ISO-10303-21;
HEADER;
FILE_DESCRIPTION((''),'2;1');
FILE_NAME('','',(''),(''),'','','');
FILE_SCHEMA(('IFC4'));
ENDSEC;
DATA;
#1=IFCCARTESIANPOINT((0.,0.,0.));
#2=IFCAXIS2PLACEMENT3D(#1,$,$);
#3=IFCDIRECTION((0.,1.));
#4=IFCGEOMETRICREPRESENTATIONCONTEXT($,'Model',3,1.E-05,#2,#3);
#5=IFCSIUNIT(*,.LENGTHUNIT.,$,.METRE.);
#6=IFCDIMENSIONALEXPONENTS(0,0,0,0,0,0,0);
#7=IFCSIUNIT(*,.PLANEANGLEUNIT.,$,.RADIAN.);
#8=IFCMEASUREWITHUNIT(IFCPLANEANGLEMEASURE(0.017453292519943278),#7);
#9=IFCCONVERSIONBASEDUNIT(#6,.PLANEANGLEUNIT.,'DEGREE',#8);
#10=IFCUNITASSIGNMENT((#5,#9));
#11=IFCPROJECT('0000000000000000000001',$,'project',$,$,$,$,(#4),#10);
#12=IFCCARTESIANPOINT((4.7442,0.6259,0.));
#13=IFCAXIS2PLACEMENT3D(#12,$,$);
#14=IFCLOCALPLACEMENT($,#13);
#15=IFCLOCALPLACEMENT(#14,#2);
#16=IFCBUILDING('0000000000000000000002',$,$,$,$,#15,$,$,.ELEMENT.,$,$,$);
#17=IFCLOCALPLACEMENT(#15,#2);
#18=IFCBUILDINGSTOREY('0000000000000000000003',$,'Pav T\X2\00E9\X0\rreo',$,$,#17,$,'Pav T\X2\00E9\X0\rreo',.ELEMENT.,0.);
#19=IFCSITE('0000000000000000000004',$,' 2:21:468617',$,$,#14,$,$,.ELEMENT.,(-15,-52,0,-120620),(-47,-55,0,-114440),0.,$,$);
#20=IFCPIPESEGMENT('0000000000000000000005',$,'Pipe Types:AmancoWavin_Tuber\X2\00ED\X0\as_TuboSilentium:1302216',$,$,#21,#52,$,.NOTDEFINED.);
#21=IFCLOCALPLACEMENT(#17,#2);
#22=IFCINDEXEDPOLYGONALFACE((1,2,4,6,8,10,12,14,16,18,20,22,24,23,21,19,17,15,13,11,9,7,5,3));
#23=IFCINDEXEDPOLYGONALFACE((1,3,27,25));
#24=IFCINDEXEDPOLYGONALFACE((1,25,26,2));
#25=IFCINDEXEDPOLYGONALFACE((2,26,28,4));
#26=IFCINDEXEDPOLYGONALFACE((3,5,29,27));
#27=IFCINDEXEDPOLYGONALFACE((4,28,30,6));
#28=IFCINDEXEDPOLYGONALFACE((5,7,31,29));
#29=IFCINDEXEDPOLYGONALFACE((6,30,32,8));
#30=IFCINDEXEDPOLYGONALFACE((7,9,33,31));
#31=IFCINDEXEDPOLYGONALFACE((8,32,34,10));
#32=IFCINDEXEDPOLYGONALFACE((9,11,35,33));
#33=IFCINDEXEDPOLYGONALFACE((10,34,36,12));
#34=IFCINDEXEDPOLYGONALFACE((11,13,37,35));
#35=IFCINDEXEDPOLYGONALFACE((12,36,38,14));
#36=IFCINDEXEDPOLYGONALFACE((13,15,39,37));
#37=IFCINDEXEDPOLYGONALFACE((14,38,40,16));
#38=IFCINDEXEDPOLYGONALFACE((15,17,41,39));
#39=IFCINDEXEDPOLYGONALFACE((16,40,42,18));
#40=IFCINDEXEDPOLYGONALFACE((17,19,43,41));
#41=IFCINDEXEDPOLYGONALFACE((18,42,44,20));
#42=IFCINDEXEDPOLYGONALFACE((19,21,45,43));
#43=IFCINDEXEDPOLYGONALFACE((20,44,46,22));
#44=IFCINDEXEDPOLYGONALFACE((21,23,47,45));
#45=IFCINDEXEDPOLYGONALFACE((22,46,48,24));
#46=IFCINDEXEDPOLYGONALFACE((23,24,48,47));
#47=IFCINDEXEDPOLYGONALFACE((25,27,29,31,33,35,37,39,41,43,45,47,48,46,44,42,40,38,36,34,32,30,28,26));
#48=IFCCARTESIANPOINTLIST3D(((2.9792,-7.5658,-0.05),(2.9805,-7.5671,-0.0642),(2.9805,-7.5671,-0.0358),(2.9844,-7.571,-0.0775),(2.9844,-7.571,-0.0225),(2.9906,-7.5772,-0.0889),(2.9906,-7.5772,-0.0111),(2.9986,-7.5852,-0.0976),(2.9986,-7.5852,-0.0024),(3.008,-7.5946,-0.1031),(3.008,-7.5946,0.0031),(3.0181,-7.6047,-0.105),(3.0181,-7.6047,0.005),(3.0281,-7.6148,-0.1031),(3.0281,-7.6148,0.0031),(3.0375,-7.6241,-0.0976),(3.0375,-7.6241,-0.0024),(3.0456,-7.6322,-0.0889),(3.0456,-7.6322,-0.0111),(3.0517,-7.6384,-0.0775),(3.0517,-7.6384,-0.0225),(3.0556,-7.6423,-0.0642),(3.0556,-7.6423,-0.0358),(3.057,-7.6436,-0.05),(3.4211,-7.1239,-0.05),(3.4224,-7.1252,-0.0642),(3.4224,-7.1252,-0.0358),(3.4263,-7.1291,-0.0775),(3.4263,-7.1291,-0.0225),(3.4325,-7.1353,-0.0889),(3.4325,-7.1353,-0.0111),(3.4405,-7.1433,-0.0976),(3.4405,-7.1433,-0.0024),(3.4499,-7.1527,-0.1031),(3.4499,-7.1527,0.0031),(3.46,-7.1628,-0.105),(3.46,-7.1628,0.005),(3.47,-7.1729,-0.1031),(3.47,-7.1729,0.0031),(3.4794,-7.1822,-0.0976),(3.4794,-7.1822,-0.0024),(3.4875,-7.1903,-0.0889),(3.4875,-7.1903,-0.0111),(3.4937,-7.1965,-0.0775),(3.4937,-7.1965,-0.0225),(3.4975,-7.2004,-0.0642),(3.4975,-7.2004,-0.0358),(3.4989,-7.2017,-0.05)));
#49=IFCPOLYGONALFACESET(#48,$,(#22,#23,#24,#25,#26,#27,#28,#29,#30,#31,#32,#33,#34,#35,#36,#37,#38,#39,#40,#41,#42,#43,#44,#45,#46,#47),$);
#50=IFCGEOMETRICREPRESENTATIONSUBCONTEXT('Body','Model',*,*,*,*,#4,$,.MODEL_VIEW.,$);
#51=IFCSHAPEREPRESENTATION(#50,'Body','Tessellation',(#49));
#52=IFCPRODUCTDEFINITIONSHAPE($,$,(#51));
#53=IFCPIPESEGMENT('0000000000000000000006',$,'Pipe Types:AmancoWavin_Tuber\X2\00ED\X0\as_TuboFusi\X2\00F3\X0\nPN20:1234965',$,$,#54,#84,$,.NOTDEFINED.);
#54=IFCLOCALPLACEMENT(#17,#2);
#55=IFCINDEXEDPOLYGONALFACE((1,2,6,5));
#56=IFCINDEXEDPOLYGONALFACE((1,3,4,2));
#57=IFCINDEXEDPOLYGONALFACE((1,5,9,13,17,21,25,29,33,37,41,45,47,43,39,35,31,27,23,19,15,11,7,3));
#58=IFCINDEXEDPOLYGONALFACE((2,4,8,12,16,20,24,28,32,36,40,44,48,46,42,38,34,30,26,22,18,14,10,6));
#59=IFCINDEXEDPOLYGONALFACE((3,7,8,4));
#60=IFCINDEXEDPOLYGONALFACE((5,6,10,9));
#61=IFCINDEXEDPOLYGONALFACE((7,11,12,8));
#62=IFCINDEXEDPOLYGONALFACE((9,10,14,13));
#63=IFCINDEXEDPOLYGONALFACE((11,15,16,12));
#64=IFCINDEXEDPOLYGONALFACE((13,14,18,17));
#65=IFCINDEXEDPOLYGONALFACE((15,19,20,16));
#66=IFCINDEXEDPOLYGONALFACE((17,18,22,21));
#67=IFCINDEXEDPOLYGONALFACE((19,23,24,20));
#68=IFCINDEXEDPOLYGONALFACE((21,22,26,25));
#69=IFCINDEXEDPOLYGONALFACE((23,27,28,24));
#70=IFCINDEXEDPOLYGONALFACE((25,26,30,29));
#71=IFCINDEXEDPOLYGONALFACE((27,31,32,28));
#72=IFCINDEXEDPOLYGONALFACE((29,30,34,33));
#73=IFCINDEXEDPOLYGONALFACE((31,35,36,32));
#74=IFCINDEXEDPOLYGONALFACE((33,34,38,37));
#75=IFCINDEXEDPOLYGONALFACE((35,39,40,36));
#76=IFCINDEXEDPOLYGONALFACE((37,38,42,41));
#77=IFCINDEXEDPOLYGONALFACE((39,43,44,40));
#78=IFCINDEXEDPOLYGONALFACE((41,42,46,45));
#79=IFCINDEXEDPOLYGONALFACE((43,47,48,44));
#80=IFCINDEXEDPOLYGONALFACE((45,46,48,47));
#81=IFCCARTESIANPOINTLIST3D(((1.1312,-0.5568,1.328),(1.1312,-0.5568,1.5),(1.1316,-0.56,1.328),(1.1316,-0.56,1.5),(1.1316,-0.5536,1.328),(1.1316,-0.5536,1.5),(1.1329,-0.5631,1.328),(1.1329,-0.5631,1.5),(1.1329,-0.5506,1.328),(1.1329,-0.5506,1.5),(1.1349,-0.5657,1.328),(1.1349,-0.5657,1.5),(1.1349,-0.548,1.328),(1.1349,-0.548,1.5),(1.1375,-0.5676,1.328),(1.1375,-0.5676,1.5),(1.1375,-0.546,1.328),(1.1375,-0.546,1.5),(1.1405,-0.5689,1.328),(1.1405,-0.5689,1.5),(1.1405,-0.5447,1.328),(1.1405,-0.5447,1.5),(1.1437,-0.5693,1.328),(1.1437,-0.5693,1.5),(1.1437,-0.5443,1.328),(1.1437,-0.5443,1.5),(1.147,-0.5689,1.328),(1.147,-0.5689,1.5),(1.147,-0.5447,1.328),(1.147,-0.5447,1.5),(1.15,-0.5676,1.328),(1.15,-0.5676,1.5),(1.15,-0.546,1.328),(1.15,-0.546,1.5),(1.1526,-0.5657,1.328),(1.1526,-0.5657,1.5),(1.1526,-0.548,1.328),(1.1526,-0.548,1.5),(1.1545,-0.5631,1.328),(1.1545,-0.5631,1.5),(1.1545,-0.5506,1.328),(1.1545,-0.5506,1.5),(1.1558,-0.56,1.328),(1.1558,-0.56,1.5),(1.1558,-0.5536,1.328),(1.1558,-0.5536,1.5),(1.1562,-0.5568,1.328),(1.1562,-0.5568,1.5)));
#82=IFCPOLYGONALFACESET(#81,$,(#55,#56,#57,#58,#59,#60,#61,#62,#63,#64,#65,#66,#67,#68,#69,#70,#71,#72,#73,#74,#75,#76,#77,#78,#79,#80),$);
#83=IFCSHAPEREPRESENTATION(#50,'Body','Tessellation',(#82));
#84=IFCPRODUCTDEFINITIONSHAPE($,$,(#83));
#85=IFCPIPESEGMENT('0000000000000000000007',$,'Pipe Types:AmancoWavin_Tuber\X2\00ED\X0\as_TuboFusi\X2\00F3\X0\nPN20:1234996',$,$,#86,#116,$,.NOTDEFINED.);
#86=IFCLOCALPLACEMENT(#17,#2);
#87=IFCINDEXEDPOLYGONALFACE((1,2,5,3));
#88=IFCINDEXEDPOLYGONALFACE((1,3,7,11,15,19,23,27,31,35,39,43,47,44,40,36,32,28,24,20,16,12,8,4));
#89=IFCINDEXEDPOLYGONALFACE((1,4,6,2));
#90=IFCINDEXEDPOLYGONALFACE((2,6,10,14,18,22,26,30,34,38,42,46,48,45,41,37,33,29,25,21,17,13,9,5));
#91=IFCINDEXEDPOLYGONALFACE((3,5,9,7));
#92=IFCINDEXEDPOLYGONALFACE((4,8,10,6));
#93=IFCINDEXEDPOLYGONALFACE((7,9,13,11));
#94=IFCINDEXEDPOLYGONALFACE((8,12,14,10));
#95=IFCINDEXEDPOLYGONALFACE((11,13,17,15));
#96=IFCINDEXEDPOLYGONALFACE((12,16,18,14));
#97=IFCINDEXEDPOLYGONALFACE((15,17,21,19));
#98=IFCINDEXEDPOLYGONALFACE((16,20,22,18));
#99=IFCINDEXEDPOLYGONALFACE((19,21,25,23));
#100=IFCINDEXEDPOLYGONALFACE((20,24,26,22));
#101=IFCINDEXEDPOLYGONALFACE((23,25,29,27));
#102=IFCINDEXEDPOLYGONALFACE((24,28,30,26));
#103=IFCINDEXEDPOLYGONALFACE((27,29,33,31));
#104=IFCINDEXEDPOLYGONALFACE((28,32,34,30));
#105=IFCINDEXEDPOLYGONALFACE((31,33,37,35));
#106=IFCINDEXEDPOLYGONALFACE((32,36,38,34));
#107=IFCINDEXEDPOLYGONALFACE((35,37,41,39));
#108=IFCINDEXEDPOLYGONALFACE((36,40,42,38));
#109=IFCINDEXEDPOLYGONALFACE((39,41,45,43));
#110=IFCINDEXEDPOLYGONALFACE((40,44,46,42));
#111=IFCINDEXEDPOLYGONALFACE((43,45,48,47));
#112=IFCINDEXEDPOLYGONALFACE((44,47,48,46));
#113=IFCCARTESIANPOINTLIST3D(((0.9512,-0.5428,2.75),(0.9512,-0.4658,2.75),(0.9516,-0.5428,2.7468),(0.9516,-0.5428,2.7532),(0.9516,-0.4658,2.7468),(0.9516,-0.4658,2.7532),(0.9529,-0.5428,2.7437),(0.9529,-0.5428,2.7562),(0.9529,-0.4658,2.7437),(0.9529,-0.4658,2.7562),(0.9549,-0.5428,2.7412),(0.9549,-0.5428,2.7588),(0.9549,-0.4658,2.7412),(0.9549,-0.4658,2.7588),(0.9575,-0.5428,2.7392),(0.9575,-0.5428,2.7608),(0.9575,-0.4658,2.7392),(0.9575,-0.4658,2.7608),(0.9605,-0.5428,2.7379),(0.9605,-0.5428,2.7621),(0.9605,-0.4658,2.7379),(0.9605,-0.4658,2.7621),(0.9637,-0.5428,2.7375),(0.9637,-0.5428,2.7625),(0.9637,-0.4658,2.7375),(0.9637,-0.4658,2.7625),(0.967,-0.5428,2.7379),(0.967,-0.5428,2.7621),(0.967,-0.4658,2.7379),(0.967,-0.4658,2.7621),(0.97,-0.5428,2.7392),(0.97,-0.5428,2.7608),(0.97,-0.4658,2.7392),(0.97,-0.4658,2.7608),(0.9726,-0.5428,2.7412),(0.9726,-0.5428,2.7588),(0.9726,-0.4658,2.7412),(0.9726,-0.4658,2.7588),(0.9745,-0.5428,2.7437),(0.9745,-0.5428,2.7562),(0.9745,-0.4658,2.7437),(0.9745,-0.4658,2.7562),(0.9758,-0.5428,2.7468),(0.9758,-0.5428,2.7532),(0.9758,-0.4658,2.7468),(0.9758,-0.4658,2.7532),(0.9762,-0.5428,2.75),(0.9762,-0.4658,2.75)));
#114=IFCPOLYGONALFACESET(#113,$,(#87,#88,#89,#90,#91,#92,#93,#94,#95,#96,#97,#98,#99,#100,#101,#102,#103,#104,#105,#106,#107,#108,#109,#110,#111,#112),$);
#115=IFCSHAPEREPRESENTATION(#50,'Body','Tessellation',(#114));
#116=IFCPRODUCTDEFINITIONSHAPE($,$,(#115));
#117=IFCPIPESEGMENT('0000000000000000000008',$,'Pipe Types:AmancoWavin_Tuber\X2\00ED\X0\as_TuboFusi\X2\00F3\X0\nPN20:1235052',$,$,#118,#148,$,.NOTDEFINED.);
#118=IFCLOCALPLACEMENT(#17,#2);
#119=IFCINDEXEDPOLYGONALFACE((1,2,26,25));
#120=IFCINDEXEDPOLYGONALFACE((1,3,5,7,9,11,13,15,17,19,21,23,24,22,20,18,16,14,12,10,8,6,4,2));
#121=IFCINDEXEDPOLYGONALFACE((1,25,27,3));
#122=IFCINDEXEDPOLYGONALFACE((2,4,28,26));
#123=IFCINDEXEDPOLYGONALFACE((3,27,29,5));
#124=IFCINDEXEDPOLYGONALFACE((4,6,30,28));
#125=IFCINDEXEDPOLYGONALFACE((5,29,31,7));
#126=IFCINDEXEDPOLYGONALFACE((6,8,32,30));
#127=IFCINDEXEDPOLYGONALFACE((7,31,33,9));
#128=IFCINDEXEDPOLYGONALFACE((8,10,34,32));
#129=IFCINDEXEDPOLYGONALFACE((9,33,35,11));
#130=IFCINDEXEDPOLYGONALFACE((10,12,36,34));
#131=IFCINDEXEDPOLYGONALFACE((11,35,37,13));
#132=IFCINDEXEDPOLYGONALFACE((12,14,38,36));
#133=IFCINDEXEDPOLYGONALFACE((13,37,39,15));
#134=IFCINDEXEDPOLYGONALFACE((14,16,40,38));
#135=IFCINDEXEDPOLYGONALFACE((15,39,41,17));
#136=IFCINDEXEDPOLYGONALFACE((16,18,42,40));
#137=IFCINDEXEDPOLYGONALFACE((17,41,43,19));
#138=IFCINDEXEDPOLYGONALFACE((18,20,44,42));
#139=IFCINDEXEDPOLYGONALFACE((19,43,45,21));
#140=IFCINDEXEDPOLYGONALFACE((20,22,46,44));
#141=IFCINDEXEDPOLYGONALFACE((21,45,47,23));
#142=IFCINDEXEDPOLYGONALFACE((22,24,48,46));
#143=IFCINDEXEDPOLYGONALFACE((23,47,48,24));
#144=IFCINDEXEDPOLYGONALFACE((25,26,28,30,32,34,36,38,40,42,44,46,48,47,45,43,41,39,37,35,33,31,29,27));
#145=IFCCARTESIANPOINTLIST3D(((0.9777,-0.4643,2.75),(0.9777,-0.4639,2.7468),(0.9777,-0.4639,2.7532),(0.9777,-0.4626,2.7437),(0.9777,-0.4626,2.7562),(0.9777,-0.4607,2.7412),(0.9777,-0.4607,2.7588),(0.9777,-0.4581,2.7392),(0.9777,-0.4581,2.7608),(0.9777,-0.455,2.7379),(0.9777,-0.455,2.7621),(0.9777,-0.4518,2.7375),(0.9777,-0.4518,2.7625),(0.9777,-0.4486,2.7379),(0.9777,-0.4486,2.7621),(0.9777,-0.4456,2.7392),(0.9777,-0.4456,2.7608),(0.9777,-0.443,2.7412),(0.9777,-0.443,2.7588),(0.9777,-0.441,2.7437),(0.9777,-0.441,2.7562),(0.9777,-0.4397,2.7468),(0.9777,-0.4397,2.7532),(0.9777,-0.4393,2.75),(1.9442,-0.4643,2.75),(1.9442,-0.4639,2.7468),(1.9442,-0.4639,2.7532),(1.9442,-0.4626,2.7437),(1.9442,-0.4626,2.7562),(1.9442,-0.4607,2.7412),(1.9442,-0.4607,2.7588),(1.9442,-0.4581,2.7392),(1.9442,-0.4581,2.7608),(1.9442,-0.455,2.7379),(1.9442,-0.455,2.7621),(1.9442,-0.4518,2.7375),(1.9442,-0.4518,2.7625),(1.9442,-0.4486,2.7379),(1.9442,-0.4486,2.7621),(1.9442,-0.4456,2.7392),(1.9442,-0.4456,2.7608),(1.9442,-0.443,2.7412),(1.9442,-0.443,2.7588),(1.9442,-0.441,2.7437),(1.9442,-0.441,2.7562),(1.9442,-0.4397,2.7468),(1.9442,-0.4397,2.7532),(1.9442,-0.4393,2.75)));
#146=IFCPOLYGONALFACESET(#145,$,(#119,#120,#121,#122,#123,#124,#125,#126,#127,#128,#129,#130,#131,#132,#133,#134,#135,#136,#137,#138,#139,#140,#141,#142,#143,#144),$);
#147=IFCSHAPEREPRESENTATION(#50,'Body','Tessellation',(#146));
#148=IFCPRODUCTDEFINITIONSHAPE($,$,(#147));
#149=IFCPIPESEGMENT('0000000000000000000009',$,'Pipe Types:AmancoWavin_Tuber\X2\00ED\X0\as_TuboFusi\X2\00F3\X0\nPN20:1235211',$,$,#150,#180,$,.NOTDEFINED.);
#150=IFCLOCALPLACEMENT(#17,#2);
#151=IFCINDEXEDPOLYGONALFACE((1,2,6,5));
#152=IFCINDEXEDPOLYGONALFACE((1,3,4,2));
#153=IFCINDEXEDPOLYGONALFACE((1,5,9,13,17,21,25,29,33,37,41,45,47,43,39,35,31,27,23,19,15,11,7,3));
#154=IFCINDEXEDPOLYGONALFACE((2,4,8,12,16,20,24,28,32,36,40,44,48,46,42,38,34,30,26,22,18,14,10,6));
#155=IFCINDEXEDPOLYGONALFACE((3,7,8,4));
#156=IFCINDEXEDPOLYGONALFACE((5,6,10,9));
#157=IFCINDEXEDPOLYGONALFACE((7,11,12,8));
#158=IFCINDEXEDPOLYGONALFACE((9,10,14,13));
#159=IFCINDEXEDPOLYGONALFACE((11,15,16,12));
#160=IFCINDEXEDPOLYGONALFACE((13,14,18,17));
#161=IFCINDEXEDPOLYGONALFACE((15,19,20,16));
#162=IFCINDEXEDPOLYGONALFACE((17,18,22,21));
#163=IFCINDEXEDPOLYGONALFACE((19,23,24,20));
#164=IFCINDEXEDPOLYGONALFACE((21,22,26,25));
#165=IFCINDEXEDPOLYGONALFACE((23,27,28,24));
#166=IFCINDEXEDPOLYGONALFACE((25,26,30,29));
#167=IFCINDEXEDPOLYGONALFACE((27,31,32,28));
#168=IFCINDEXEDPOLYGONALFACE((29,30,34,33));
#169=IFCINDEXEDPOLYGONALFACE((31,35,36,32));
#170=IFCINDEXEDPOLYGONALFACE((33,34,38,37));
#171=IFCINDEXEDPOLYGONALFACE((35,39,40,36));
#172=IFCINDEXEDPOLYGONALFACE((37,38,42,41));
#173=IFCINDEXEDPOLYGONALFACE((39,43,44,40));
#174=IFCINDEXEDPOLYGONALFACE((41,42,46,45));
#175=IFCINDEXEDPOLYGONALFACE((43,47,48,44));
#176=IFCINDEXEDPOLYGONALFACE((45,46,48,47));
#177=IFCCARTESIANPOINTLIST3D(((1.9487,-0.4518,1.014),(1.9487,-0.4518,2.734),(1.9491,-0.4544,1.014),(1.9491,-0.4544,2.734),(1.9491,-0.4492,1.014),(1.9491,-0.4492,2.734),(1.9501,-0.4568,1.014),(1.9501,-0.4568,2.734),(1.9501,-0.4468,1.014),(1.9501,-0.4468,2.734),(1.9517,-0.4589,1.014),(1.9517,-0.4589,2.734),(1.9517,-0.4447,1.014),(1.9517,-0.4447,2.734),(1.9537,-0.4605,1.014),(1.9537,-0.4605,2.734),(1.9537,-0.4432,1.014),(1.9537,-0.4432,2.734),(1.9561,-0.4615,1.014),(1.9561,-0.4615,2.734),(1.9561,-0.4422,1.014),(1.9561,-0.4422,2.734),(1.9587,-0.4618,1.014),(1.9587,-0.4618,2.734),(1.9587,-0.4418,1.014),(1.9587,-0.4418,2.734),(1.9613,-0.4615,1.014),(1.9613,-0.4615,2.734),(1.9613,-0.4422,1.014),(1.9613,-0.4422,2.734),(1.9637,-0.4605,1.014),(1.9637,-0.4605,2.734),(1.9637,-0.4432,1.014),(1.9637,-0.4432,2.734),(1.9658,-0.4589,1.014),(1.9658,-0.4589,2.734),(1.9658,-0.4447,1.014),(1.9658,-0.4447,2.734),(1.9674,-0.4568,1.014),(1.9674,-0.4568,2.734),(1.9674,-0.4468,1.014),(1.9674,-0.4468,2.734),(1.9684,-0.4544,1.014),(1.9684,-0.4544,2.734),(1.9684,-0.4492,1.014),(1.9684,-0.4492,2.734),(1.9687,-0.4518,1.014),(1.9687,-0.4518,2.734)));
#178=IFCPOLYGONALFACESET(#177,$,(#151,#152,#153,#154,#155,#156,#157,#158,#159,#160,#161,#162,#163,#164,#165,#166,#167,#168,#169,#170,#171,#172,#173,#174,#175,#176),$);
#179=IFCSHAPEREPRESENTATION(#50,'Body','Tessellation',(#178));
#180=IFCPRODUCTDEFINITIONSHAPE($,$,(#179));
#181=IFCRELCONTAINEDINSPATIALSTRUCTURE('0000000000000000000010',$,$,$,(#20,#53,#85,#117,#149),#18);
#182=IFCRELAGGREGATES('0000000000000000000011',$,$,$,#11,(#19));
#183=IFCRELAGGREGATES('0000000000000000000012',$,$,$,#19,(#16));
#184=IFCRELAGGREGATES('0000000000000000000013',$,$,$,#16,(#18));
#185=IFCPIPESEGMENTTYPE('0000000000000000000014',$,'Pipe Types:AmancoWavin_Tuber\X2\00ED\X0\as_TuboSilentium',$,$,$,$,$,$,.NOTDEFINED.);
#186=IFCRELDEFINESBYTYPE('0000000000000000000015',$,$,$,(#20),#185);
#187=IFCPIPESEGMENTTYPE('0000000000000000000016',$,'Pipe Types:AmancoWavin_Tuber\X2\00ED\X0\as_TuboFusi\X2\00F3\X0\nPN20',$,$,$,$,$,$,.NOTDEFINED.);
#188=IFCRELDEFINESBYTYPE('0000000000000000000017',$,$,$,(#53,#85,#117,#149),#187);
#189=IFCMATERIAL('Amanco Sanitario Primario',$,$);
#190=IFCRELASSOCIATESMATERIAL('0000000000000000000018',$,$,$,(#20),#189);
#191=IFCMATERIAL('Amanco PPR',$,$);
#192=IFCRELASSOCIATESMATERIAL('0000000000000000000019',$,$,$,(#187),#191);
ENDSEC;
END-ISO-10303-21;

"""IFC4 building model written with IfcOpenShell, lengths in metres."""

from ifc_helpers import new_model, entity, si_unit, converted_unit, direction, frame, origin, place, context, subcontext, project, spatial, arc, indexed_curve, outline, extrude, material, type_object, element, save


model = new_model("IFC4")

# Units and contexts
model_context = context("Model", 3, precision=1e-05, world=origin(), true_north=direction((0.0, 1.0)))
body_context = subcontext(model_context, "Body", "Model", "MODEL_VIEW")
ifc_project = project(units=[si_unit("LENGTHUNIT", "METRE"), converted_unit("PLANEANGLEUNIT", "DEGREE", entity("IfcPlaneAngleMeasure", 0.017453292519943278), si_unit("PLANEANGLEUNIT", "RADIAN"), dimensions=[0, 0, 0, 0, 0, 0, 0])], contexts=[model_context])

# Site, building, storey
site_placement = place(None, frame((4.7442, 0.6259, 0.0)))
site = spatial("IfcSite", under=ifc_project, at=site_placement, Name=" 2:21:468617", CompositionType="ELEMENT", RefLatitude=(-15, -52, 0, -120620), RefLongitude=(-47, -55, 0, -114440), RefElevation=0.0)
building_placement = place(site_placement, origin())
building = spatial("IfcBuilding", under=site, at=building_placement, CompositionType="ELEMENT")
storey_placement = place(building_placement, origin())
storey = spatial("IfcBuildingStorey", under=building, at=storey_placement, Name="Pav Térreo", LongName="Pav Térreo", CompositionType="ELEMENT", Elevation=0.0)

# Pipe segments
pipe_segment_type_1 = type_object("IfcPipeSegmentType", Name="Pipe Types:AmancoWavin_Tuberías_TuboSilentium", PredefinedType="NOTDEFINED")
ifc_material_1 = material(Name="Amanco Sanitario Primario")
pipe_segment_1_placement = place(storey_placement, origin())
element("IfcPipeSegment", 1, at=pipe_segment_1_placement, inside=storey, type_object=pipe_segment_type_1, material=ifc_material_1, Name="Pipe Types:AmancoWavin_Tuberías_TuboSilentium:1302216", PredefinedType="NOTDEFINED", context=body_context, shape_type="SweptSolid", body=[
    extrude(outline(indexed_curve([(0.055, 0.0), (0.0389, 0.0389), (0.0, 0.055), (-0.0389, 0.0389), (-0.055, 0.0), (-0.0389, -0.0389), (0.0, -0.055), (0.0389, -0.0389)], segments=[arc(1, 2, 3), arc(3, 4, 5), arc(5, 6, 7), arc(7, 8, 1)], self_intersect=False)), frame((3.0181, -7.6047, -0.05), z_axis=(0.707107, 0.707107, 0.0), x_axis=(0.707107, -0.707107, 0.0)), (0.0, 0.0, 1.0), 0.6249),
])
ifc_material_2 = material(Name="Amanco PPR")
pipe_segment_type_2 = type_object("IfcPipeSegmentType", Name="Pipe Types:AmancoWavin_Tuberías_TuboFusiónPN20", PredefinedType="NOTDEFINED", material=ifc_material_2)
pipe_segment_2_placement = place(storey_placement, origin())
element("IfcPipeSegment", 2, at=pipe_segment_2_placement, inside=storey, type_object=pipe_segment_type_2, Name="Pipe Types:AmancoWavin_Tuberías_TuboFusiónPN20:1234965", PredefinedType="NOTDEFINED", context=body_context, shape_type="SweptSolid", body=[
    extrude(outline(indexed_curve([(0.0125, 0.0), (0.0088, 0.0088), (0.0, 0.0125), (-0.0088, 0.0088), (-0.0125, 0.0), (-0.0088, -0.0088), (0.0, -0.0125), (0.0088, -0.0088)], segments=[arc(1, 2, 3), arc(3, 4, 5), arc(5, 6, 7), arc(7, 8, 1)], self_intersect=False)), frame((1.1437, -0.5568, 1.328), z_axis=(0.0, 0.0, 1.0), x_axis=(-1.0, 0.0, 0.0)), (0.0, 0.0, 1.0), 0.172),
])
pipe_segment_3_placement = place(storey_placement, origin())
element("IfcPipeSegment", 3, at=pipe_segment_3_placement, inside=storey, type_object=pipe_segment_type_2, Name="Pipe Types:AmancoWavin_Tuberías_TuboFusiónPN20:1234996", PredefinedType="NOTDEFINED", context=body_context, shape_type="SweptSolid", body=[
    extrude(outline(indexed_curve([(0.0125, 0.0), (0.0088, 0.0088), (0.0, 0.0125), (-0.0088, 0.0088), (-0.0125, 0.0), (-0.0088, -0.0088), (0.0, -0.0125), (0.0088, -0.0088)], segments=[arc(1, 2, 3), arc(3, 4, 5), arc(5, 6, 7), arc(7, 8, 1)], self_intersect=False)), frame((0.9637, -0.5428, 2.75), z_axis=(0.0, 1.0, 0.0), x_axis=(1.0, 0.0, 0.0)), (0.0, 0.0, 1.0), 0.077),
])
pipe_segment_4_placement = place(storey_placement, origin())
element("IfcPipeSegment", 4, at=pipe_segment_4_placement, inside=storey, type_object=pipe_segment_type_2, Name="Pipe Types:AmancoWavin_Tuberías_TuboFusiónPN20:1235052", PredefinedType="NOTDEFINED", context=body_context, shape_type="SweptSolid", body=[
    extrude(outline(indexed_curve([(0.0125, 0.0), (0.0088, 0.0088), (0.0, 0.0125), (-0.0088, 0.0088), (-0.0125, 0.0), (-0.0088, -0.0088), (0.0, -0.0125), (0.0088, -0.0088)], segments=[arc(1, 2, 3), arc(3, 4, 5), arc(5, 6, 7), arc(7, 8, 1)], self_intersect=False)), frame((0.9777, -0.4518, 2.75), z_axis=(1.0, 0.0, 0.0), x_axis=(0.0, -1.0, 0.0)), (0.0, 0.0, 1.0), 0.9665),
])
pipe_segment_5_placement = place(storey_placement, origin())
element("IfcPipeSegment", 5, at=pipe_segment_5_placement, inside=storey, type_object=pipe_segment_type_2, Name="Pipe Types:AmancoWavin_Tuberías_TuboFusiónPN20:1235211", PredefinedType="NOTDEFINED", context=body_context, shape_type="SweptSolid", body=[
    extrude(outline(indexed_curve([(0.01, 0.0), (0.0071, 0.0071), (0.0, 0.01), (-0.0071, 0.0071), (-0.01, 0.0), (-0.0071, -0.0071), (0.0, -0.01), (0.0071, -0.0071)], segments=[arc(1, 2, 3), arc(3, 4, 5), arc(5, 6, 7), arc(7, 8, 1)], self_intersect=False)), frame((1.9587, -0.4518, 1.014)), (0.0, 0.0, 1.0), 1.72),
])

save(model, "model.ifc")
